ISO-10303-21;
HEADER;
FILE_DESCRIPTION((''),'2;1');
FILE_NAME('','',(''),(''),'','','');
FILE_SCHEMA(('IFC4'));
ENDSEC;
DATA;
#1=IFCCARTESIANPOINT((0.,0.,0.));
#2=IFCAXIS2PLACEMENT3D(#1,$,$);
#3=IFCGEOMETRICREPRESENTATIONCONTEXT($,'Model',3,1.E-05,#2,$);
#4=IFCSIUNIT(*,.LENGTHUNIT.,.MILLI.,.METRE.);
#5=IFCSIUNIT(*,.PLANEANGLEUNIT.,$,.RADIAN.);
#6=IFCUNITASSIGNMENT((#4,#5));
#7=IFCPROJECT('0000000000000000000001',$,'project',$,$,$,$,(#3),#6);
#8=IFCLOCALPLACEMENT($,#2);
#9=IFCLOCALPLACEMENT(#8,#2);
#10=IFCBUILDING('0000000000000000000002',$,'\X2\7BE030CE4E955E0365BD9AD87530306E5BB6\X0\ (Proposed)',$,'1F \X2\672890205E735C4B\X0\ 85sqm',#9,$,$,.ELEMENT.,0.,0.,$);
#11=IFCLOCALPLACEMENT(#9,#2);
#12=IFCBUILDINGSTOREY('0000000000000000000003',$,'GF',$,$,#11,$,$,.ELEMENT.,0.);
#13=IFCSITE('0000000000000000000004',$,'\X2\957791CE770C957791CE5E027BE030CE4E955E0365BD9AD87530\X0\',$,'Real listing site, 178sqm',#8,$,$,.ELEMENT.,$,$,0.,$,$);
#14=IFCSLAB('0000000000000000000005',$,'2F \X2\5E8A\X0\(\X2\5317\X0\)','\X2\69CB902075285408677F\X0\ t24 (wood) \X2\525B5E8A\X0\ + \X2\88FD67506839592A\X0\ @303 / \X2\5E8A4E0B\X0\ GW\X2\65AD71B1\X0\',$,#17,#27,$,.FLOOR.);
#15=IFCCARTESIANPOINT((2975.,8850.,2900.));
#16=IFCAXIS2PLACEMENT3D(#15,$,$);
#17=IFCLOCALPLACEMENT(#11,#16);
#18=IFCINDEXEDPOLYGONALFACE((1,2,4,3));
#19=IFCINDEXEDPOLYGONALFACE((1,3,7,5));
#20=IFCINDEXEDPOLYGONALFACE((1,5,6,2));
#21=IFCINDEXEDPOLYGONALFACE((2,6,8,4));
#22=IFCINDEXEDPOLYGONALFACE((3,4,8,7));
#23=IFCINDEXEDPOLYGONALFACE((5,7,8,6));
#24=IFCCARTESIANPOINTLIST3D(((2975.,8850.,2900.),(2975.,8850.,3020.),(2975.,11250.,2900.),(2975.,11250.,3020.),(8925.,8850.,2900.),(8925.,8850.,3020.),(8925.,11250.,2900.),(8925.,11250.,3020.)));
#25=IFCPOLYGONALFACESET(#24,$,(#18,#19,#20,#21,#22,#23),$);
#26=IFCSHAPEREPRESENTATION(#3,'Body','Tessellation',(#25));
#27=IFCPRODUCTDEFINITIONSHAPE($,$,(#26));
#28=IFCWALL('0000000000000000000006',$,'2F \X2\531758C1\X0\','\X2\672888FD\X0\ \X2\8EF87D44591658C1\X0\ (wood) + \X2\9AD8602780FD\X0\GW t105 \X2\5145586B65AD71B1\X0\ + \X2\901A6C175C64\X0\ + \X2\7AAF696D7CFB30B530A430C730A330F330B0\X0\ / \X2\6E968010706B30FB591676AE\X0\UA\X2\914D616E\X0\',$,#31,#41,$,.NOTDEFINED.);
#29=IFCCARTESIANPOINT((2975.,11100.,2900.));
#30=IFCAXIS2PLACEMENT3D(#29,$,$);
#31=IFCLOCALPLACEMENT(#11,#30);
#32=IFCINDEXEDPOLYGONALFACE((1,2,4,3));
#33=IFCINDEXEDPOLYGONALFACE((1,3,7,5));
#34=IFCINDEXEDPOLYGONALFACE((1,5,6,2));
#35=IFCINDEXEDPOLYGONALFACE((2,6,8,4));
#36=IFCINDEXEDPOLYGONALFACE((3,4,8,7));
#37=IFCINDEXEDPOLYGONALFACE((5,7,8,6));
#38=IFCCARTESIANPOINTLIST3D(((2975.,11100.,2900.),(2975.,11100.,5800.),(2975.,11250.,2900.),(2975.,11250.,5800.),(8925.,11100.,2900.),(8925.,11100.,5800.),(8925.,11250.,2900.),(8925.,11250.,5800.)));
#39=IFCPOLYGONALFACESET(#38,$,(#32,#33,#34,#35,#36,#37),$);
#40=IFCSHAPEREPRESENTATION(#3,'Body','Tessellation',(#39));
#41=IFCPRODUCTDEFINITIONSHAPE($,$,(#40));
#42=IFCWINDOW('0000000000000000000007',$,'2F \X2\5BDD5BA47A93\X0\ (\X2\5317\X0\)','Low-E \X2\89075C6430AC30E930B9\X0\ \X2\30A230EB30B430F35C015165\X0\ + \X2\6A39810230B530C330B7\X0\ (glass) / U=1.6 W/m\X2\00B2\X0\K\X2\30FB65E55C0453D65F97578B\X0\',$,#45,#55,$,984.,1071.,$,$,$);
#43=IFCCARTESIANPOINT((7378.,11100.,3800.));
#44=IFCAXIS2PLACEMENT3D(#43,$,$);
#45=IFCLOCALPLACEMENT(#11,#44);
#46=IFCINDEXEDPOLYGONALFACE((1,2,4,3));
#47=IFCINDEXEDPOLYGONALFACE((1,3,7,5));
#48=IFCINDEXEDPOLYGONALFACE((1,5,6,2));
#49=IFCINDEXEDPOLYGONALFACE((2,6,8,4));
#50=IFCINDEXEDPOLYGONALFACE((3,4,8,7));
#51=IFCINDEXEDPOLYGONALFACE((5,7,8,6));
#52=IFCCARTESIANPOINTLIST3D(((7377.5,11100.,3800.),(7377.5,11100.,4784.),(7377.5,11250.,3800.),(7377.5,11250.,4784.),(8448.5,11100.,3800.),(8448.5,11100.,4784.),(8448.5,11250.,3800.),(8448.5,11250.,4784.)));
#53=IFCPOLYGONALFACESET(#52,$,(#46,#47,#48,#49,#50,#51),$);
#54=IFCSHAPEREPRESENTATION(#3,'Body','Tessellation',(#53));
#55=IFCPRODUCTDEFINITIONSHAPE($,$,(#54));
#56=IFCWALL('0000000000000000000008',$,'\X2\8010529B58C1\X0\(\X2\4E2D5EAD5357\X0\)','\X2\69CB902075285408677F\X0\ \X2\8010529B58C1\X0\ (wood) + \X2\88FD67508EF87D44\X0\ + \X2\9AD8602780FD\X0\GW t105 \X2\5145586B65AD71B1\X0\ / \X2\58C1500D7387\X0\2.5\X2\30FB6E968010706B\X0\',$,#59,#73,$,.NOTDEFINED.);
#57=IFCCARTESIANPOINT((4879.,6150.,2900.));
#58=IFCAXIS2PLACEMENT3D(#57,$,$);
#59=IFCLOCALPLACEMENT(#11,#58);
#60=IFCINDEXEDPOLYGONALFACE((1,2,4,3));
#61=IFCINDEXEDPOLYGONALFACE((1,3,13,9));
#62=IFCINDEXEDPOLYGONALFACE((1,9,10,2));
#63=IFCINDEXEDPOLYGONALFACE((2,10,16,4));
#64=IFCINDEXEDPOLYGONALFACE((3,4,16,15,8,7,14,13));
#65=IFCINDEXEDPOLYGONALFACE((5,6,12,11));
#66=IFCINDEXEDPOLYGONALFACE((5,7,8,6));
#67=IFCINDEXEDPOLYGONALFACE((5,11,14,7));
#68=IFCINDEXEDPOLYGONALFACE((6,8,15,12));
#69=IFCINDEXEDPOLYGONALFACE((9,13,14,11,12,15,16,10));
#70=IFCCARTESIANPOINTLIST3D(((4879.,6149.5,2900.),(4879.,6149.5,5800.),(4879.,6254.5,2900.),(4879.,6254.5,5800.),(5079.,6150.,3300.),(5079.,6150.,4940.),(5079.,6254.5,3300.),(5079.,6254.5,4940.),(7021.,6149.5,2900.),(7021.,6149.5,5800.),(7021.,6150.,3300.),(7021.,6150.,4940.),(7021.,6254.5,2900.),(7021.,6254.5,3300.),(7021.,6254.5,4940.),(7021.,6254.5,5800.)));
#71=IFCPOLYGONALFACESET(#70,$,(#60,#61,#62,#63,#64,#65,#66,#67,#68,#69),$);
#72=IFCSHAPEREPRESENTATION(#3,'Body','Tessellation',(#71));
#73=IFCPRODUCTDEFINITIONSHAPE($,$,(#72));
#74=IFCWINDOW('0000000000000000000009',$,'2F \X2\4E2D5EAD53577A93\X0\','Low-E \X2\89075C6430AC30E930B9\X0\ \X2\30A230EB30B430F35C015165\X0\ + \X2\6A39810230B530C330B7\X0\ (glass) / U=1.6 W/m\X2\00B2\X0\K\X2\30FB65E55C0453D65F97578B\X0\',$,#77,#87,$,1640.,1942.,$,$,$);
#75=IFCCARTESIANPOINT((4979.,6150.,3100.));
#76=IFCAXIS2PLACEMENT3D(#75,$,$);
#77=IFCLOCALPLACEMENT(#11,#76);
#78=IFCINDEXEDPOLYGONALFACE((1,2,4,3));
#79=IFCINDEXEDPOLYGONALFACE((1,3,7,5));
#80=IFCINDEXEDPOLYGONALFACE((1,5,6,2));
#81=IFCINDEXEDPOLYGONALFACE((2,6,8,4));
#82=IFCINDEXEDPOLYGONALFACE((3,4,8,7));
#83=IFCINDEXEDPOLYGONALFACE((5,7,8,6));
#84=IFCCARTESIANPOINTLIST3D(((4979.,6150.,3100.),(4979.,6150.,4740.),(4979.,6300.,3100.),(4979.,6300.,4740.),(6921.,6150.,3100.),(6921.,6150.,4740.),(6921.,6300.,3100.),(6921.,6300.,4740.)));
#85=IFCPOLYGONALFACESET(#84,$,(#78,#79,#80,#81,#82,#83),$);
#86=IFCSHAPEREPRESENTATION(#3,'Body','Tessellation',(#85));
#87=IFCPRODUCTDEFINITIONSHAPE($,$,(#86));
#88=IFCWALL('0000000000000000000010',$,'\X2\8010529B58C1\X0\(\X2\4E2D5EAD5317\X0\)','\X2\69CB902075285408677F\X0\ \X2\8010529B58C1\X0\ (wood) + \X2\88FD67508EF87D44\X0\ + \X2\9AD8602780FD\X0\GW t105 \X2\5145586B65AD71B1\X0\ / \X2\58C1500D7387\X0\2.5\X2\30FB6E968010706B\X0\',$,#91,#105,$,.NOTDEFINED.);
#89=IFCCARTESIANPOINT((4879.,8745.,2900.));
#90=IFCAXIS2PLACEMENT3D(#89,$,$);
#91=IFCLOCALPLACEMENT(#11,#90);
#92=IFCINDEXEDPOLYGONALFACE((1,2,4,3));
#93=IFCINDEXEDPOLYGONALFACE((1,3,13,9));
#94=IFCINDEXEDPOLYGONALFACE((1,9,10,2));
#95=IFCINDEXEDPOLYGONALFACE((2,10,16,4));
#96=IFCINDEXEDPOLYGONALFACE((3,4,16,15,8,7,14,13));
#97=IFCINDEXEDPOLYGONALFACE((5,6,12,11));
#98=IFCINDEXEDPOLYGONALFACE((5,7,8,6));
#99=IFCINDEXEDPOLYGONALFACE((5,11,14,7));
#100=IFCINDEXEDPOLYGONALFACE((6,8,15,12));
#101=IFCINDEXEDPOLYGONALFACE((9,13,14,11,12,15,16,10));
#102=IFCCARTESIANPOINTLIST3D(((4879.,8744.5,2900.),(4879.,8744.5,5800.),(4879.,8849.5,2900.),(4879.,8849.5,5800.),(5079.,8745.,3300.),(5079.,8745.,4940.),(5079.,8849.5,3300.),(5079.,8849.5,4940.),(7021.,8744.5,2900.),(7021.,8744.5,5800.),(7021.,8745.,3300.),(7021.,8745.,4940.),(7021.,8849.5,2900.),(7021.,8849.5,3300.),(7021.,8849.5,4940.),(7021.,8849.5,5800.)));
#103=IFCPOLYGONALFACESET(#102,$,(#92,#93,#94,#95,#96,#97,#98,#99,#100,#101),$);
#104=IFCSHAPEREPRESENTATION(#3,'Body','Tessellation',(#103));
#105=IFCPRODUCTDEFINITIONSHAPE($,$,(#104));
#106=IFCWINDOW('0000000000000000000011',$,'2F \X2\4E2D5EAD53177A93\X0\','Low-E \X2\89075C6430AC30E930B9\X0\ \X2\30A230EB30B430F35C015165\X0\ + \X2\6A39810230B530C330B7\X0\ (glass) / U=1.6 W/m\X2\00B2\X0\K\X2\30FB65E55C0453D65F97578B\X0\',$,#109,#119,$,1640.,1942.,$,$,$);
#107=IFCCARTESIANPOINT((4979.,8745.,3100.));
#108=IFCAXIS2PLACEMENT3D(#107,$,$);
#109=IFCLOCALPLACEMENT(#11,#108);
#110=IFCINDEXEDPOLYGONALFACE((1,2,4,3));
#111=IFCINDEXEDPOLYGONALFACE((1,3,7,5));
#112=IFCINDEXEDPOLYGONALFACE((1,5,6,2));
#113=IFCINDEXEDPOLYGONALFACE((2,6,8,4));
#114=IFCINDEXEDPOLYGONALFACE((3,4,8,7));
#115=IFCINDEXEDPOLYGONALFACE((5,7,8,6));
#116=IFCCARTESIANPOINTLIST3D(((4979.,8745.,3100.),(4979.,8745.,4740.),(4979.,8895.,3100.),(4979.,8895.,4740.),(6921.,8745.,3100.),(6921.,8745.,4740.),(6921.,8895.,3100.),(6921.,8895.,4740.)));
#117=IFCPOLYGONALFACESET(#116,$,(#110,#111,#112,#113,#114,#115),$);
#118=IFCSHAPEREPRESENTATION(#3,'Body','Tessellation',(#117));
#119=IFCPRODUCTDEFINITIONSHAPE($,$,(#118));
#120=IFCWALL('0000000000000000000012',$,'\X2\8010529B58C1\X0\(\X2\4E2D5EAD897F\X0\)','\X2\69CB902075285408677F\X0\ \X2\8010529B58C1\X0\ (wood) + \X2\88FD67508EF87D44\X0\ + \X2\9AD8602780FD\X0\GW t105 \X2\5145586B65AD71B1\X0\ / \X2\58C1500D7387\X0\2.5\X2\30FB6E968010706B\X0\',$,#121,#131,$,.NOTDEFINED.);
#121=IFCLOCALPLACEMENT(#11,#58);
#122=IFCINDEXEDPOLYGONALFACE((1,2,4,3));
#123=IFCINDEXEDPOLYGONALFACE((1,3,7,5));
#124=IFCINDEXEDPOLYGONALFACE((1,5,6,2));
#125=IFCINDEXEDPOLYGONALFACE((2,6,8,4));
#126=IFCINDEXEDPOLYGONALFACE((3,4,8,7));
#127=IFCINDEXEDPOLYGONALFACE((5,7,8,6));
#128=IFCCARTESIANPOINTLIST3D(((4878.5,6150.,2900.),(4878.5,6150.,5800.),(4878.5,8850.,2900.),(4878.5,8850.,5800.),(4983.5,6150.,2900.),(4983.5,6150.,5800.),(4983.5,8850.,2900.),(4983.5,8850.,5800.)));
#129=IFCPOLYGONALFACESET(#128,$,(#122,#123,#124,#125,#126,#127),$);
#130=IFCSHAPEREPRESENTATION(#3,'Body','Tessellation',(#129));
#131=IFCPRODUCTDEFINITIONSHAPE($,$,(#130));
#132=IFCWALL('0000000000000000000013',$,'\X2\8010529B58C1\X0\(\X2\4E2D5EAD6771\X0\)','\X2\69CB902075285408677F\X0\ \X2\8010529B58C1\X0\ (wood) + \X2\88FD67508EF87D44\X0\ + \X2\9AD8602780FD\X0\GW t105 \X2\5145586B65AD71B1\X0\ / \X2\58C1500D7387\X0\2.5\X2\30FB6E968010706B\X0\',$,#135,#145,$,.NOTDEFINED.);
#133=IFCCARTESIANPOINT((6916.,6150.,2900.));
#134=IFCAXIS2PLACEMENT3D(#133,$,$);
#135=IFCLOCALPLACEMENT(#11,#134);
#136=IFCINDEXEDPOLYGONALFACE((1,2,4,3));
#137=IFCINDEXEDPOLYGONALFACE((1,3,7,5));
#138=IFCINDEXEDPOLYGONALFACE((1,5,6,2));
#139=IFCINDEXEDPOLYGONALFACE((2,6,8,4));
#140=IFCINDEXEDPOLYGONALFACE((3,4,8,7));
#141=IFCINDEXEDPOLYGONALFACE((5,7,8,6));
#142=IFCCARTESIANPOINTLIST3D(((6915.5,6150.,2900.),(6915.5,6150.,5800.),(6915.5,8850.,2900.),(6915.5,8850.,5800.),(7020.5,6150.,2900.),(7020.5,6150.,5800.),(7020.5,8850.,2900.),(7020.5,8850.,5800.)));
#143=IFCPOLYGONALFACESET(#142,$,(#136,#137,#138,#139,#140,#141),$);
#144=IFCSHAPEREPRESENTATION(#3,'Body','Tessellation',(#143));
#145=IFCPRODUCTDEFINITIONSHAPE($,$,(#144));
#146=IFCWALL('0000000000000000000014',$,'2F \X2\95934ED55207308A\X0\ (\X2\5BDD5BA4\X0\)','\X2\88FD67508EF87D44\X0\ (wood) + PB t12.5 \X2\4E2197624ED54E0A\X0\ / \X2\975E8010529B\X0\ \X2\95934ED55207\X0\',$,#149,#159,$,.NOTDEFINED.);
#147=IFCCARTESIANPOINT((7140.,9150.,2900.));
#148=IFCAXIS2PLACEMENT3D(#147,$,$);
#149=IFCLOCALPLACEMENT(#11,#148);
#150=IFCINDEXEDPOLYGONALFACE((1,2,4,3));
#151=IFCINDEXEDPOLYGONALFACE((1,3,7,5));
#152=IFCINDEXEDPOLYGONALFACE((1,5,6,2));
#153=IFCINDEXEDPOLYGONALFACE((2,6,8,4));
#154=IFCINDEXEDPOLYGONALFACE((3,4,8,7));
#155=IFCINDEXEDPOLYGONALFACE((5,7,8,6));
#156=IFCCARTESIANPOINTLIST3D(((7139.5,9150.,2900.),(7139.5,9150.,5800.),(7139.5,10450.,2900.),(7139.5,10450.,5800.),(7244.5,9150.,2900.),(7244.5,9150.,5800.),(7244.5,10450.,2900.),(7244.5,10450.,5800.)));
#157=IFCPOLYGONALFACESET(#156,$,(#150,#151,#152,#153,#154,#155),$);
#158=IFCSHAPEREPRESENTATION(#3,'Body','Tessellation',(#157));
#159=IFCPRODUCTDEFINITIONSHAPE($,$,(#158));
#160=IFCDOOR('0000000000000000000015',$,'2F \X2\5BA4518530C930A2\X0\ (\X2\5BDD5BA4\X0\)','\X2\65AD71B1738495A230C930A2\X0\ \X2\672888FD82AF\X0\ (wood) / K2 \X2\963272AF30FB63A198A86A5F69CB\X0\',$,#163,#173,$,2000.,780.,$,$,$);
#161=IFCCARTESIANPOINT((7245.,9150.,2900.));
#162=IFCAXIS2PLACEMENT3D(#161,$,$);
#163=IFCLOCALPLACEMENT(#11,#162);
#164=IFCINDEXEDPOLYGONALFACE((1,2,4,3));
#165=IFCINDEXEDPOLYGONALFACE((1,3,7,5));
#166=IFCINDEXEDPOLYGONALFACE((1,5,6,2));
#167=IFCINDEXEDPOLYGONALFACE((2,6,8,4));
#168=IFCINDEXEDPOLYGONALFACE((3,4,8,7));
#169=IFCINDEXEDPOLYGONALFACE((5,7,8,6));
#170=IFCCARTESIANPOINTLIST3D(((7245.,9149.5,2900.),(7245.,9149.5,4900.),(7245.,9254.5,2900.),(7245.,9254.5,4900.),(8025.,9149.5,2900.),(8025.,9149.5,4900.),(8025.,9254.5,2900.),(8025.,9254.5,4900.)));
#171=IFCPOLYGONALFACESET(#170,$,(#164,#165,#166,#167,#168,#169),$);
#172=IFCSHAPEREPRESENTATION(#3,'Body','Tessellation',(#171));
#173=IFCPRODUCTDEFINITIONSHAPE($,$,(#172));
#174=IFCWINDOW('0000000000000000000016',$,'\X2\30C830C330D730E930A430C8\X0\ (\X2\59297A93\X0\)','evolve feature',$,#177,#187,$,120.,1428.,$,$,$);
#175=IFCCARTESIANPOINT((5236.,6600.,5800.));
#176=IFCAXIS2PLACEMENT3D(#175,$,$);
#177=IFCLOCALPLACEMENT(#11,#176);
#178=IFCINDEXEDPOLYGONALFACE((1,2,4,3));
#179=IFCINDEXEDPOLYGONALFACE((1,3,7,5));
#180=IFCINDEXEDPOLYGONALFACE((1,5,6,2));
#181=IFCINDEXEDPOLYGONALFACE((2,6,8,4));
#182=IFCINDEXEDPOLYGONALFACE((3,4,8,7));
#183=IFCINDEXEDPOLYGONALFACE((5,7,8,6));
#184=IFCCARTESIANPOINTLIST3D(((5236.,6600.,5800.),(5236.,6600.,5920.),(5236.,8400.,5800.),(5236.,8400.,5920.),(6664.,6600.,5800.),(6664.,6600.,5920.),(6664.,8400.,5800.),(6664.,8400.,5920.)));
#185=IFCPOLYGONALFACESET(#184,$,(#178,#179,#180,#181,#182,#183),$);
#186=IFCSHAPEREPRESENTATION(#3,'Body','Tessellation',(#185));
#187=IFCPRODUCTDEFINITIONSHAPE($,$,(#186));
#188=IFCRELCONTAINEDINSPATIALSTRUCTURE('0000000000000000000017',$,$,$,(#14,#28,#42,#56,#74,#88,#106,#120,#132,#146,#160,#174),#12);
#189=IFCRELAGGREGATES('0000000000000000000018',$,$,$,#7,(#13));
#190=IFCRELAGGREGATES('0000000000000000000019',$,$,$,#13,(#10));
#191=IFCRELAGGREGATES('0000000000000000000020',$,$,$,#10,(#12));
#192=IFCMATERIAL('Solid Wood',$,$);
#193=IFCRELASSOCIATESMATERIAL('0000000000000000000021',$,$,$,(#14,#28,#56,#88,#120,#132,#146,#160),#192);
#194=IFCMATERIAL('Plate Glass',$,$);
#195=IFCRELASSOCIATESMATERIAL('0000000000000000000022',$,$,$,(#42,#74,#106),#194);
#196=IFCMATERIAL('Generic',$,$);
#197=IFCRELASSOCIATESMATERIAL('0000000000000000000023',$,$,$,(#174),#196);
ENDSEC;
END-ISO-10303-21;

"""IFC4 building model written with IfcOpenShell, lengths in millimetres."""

from ifc_helpers import new_model, si_unit, frame, frame_2d, origin, place, context, project, spatial, rectangle, extrude, material, element, fill, save


model = new_model("IFC4")

# Units and contexts
model_context = context("Model", 3, precision=1e-05, world=origin())
ifc_project = project(units=[si_unit("LENGTHUNIT", "METRE", prefix="MILLI"), si_unit("PLANEANGLEUNIT", "RADIAN")], contexts=[model_context])

# Site, building, storey
site_placement = place(None, origin())
site = spatial("IfcSite", under=ifc_project, at=site_placement, Name="長野県長野市篠ノ井布施高田", ObjectType="Real listing site, 178sqm", CompositionType="ELEMENT", RefElevation=0.0)
building_placement = place(site_placement, origin())
building = spatial("IfcBuilding", under=site, at=building_placement, Name="篠ノ井布施高田の家 (Proposed)", ObjectType="1F 木造平屋 85sqm", CompositionType="ELEMENT", ElevationOfRefHeight=0.0, ElevationOfTerrain=0.0)
storey_placement = place(building_placement, origin())
storey = spatial("IfcBuildingStorey", under=building, at=storey_placement, Name="GF", CompositionType="ELEMENT", Elevation=0.0)

# Slab
ifc_material_1 = material(Name="Solid Wood")
slab_placement = place(storey_placement, frame((2975.0, 8850.0, 2900.0)))
element("IfcSlab", 1, at=slab_placement, inside=storey, material=ifc_material_1, Name="2F 床(北)", Description="構造用合板 t24 (wood) 剛床 + 製材根太 @303 / 床下 GW断熱", PredefinedType="FLOOR", context=model_context, shape_type="SweptSolid", body=[
    extrude(rectangle(XDim=5950.0, YDim=2400.0, at=frame_2d((2975.0, 1200.0))), frame((2975.0, 8850.0, 2900.0)), (0.0, 0.0, 1.0), 120.0),
])

# Walls, openings, windows
wall_1_placement = place(storey_placement, frame((2975.0, 11100.0, 2900.0)))
wall_1 = element("IfcWall", 2, at=wall_1_placement, inside=storey, material=ifc_material_1, Name="2F 北壁", Description="木製 軸組外壁 (wood) + 高性能GW t105 充填断熱 + 通気層 + 窯業系サイディング / 準耐火・外皮UA配慮", PredefinedType="NOTDEFINED", context=model_context, shape_type="SweptSolid", body=[
    extrude(rectangle(XDim=5950.0, YDim=150.0, at=frame_2d((2975.0, 75.0))), frame((2975.0, 11100.0, 2900.0)), (0.0, 0.0, 1.0), 2900.0),
])
opening_1_placement = place(storey_placement, frame((7378.0, 11100.0, 3800.0)))
opening_1 = element("IfcOpeningElement", 3, at=opening_1_placement, cuts=wall_1, PredefinedType="NOTDEFINED", context=model_context, shape_type="SweptSolid", body=[
    extrude(rectangle(XDim=1071.0, YDim=150.0, at=frame_2d((535.0, 75.0))), frame((7378.0, 11100.0, 3800.0)), (0.0, 0.0, 1.0), 984.0),
])
ifc_material_2 = material(Name="Plate Glass")
window_1_placement = place(storey_placement, frame((7378.0, 11100.0, 3800.0)))
window_1 = element("IfcWindow", 4, at=window_1_placement, inside=storey, material=ifc_material_2, Name="2F 寝室窓 (北)", Description="Low-E 複層ガラス アルゴン封入 + 樹脂サッシ (glass) / U=1.6 W/m²K・日射取得型", OverallHeight=984.0, OverallWidth=1071.0, context=model_context, shape_type="SweptSolid", body=[
    extrude(rectangle(XDim=1071.0, YDim=150.0, at=frame_2d((535.0, 75.0))), frame((7378.0, 11100.0, 3800.0)), (0.0, 0.0, 1.0), 984.0),
])
fill(opening_1, window_1)
wall_2_placement = place(storey_placement, frame((4879.0, 6150.0, 2900.0)))
wall_2 = element("IfcWall", 5, at=wall_2_placement, inside=storey, material=ifc_material_1, Name="耐力壁(中庭南)", Description="構造用合板 耐力壁 (wood) + 製材軸組 + 高性能GW t105 充填断熱 / 壁倍率2.5・準耐火", PredefinedType="NOTDEFINED", context=model_context, shape_type="SweptSolid", body=[
    extrude(rectangle(XDim=2142.0, YDim=105.0, at=frame_2d((1071.0, 52.0))), frame((4879.0, 6150.0, 2900.0)), (0.0, 0.0, 1.0), 2900.0),
])
opening_2_placement = place(storey_placement, frame((4979.0, 6150.0, 3100.0)))
opening_2 = element("IfcOpeningElement", 6, at=opening_2_placement, cuts=wall_2, PredefinedType="NOTDEFINED", context=model_context, shape_type="SweptSolid", body=[
    extrude(rectangle(XDim=1942.0, YDim=150.0, at=frame_2d((971.0, 75.0))), frame((4979.0, 6150.0, 3100.0)), (0.0, 0.0, 1.0), 1640.0),
])
window_2_placement = place(storey_placement, frame((4979.0, 6150.0, 3100.0)))
window_2 = element("IfcWindow", 7, at=window_2_placement, inside=storey, material=ifc_material_2, Name="2F 中庭南窓", Description="Low-E 複層ガラス アルゴン封入 + 樹脂サッシ (glass) / U=1.6 W/m²K・日射取得型", OverallHeight=1640.0, OverallWidth=1942.0, context=model_context, shape_type="SweptSolid", body=[
    extrude(rectangle(XDim=1942.0, YDim=150.0, at=frame_2d((971.0, 75.0))), frame((4979.0, 6150.0, 3100.0)), (0.0, 0.0, 1.0), 1640.0),
])
fill(opening_2, window_2)
wall_3_placement = place(storey_placement, frame((4879.0, 8745.0, 2900.0)))
wall_3 = element("IfcWall", 8, at=wall_3_placement, inside=storey, material=ifc_material_1, Name="耐力壁(中庭北)", Description="構造用合板 耐力壁 (wood) + 製材軸組 + 高性能GW t105 充填断熱 / 壁倍率2.5・準耐火", PredefinedType="NOTDEFINED", context=model_context, shape_type="SweptSolid", body=[
    extrude(rectangle(XDim=2142.0, YDim=105.0, at=frame_2d((1071.0, 52.0))), frame((4879.0, 8745.0, 2900.0)), (0.0, 0.0, 1.0), 2900.0),
])
opening_3_placement = place(storey_placement, frame((4979.0, 8745.0, 3100.0)))
opening_3 = element("IfcOpeningElement", 9, at=opening_3_placement, cuts=wall_3, PredefinedType="NOTDEFINED", context=model_context, shape_type="SweptSolid", body=[
    extrude(rectangle(XDim=1942.0, YDim=150.0, at=frame_2d((971.0, 75.0))), frame((4979.0, 8745.0, 3100.0)), (0.0, 0.0, 1.0), 1640.0),
])
window_3_placement = place(storey_placement, frame((4979.0, 8745.0, 3100.0)))
window_3 = element("IfcWindow", 10, at=window_3_placement, inside=storey, material=ifc_material_2, Name="2F 中庭北窓", Description="Low-E 複層ガラス アルゴン封入 + 樹脂サッシ (glass) / U=1.6 W/m²K・日射取得型", OverallHeight=1640.0, OverallWidth=1942.0, context=model_context, shape_type="SweptSolid", body=[
    extrude(rectangle(XDim=1942.0, YDim=150.0, at=frame_2d((971.0, 75.0))), frame((4979.0, 8745.0, 3100.0)), (0.0, 0.0, 1.0), 1640.0),
])
fill(opening_3, window_3)

# Walls
wall_4_placement = place(storey_placement, frame((4879.0, 6150.0, 2900.0)))
element("IfcWall", 11, at=wall_4_placement, inside=storey, material=ifc_material_1, Name="耐力壁(中庭西)", Description="構造用合板 耐力壁 (wood) + 製材軸組 + 高性能GW t105 充填断熱 / 壁倍率2.5・準耐火", PredefinedType="NOTDEFINED", context=model_context, shape_type="SweptSolid", body=[
    extrude(rectangle(XDim=105.0, YDim=2700.0, at=frame_2d((52.0, 1350.0))), frame((4879.0, 6150.0, 2900.0)), (0.0, 0.0, 1.0), 2900.0),
])
wall_5_placement = place(storey_placement, frame((6916.0, 6150.0, 2900.0)))
element("IfcWall", 12, at=wall_5_placement, inside=storey, material=ifc_material_1, Name="耐力壁(中庭東)", Description="構造用合板 耐力壁 (wood) + 製材軸組 + 高性能GW t105 充填断熱 / 壁倍率2.5・準耐火", PredefinedType="NOTDEFINED", context=model_context, shape_type="SweptSolid", body=[
    extrude(rectangle(XDim=105.0, YDim=2700.0, at=frame_2d((52.0, 1350.0))), frame((6916.0, 6150.0, 2900.0)), (0.0, 0.0, 1.0), 2900.0),
])
wall_6_placement = place(storey_placement, frame((7140.0, 9150.0, 2900.0)))
element("IfcWall", 13, at=wall_6_placement, inside=storey, material=ifc_material_1, Name="2F 間仕切り (寝室)", Description="製材軸組 (wood) + PB t12.5 両面仕上 / 非耐力 間仕切", PredefinedType="NOTDEFINED", context=model_context, shape_type="SweptSolid", body=[
    extrude(rectangle(XDim=105.0, YDim=1300.0, at=frame_2d((52.0, 650.0))), frame((7140.0, 9150.0, 2900.0)), (0.0, 0.0, 1.0), 2900.0),
])

# Door
door_placement = place(storey_placement, frame((7245.0, 9150.0, 2900.0)))
element("IfcDoor", 14, at=door_placement, inside=storey, material=ifc_material_1, Name="2F 室内ドア (寝室)", Description="断熱玄関ドア 木製芯 (wood) / K2 防犯・採風機構", OverallHeight=2000.0, OverallWidth=780.0, context=model_context, shape_type="SweptSolid", body=[
    extrude(rectangle(XDim=780.0, YDim=105.0, at=frame_2d((390.0, 52.0))), frame((7245.0, 9150.0, 2900.0)), (0.0, 0.0, 1.0), 2000.0),
])

# Window
ifc_material_3 = material(Name="Generic")
window_4_placement = place(storey_placement, frame((5236.0, 6600.0, 5800.0)))
element("IfcWindow", 15, at=window_4_placement, inside=storey, material=ifc_material_3, Name="トップライト (天窓)", Description="evolve feature", OverallHeight=120.0, OverallWidth=1428.0, context=model_context, shape_type="SweptSolid", body=[
    extrude(rectangle(XDim=1428.0, YDim=1800.0, at=frame_2d((714.0, 900.0))), frame((5236.0, 6600.0, 5800.0)), (0.0, 0.0, 1.0), 120.0),
])

save(model, "model.ifc")
